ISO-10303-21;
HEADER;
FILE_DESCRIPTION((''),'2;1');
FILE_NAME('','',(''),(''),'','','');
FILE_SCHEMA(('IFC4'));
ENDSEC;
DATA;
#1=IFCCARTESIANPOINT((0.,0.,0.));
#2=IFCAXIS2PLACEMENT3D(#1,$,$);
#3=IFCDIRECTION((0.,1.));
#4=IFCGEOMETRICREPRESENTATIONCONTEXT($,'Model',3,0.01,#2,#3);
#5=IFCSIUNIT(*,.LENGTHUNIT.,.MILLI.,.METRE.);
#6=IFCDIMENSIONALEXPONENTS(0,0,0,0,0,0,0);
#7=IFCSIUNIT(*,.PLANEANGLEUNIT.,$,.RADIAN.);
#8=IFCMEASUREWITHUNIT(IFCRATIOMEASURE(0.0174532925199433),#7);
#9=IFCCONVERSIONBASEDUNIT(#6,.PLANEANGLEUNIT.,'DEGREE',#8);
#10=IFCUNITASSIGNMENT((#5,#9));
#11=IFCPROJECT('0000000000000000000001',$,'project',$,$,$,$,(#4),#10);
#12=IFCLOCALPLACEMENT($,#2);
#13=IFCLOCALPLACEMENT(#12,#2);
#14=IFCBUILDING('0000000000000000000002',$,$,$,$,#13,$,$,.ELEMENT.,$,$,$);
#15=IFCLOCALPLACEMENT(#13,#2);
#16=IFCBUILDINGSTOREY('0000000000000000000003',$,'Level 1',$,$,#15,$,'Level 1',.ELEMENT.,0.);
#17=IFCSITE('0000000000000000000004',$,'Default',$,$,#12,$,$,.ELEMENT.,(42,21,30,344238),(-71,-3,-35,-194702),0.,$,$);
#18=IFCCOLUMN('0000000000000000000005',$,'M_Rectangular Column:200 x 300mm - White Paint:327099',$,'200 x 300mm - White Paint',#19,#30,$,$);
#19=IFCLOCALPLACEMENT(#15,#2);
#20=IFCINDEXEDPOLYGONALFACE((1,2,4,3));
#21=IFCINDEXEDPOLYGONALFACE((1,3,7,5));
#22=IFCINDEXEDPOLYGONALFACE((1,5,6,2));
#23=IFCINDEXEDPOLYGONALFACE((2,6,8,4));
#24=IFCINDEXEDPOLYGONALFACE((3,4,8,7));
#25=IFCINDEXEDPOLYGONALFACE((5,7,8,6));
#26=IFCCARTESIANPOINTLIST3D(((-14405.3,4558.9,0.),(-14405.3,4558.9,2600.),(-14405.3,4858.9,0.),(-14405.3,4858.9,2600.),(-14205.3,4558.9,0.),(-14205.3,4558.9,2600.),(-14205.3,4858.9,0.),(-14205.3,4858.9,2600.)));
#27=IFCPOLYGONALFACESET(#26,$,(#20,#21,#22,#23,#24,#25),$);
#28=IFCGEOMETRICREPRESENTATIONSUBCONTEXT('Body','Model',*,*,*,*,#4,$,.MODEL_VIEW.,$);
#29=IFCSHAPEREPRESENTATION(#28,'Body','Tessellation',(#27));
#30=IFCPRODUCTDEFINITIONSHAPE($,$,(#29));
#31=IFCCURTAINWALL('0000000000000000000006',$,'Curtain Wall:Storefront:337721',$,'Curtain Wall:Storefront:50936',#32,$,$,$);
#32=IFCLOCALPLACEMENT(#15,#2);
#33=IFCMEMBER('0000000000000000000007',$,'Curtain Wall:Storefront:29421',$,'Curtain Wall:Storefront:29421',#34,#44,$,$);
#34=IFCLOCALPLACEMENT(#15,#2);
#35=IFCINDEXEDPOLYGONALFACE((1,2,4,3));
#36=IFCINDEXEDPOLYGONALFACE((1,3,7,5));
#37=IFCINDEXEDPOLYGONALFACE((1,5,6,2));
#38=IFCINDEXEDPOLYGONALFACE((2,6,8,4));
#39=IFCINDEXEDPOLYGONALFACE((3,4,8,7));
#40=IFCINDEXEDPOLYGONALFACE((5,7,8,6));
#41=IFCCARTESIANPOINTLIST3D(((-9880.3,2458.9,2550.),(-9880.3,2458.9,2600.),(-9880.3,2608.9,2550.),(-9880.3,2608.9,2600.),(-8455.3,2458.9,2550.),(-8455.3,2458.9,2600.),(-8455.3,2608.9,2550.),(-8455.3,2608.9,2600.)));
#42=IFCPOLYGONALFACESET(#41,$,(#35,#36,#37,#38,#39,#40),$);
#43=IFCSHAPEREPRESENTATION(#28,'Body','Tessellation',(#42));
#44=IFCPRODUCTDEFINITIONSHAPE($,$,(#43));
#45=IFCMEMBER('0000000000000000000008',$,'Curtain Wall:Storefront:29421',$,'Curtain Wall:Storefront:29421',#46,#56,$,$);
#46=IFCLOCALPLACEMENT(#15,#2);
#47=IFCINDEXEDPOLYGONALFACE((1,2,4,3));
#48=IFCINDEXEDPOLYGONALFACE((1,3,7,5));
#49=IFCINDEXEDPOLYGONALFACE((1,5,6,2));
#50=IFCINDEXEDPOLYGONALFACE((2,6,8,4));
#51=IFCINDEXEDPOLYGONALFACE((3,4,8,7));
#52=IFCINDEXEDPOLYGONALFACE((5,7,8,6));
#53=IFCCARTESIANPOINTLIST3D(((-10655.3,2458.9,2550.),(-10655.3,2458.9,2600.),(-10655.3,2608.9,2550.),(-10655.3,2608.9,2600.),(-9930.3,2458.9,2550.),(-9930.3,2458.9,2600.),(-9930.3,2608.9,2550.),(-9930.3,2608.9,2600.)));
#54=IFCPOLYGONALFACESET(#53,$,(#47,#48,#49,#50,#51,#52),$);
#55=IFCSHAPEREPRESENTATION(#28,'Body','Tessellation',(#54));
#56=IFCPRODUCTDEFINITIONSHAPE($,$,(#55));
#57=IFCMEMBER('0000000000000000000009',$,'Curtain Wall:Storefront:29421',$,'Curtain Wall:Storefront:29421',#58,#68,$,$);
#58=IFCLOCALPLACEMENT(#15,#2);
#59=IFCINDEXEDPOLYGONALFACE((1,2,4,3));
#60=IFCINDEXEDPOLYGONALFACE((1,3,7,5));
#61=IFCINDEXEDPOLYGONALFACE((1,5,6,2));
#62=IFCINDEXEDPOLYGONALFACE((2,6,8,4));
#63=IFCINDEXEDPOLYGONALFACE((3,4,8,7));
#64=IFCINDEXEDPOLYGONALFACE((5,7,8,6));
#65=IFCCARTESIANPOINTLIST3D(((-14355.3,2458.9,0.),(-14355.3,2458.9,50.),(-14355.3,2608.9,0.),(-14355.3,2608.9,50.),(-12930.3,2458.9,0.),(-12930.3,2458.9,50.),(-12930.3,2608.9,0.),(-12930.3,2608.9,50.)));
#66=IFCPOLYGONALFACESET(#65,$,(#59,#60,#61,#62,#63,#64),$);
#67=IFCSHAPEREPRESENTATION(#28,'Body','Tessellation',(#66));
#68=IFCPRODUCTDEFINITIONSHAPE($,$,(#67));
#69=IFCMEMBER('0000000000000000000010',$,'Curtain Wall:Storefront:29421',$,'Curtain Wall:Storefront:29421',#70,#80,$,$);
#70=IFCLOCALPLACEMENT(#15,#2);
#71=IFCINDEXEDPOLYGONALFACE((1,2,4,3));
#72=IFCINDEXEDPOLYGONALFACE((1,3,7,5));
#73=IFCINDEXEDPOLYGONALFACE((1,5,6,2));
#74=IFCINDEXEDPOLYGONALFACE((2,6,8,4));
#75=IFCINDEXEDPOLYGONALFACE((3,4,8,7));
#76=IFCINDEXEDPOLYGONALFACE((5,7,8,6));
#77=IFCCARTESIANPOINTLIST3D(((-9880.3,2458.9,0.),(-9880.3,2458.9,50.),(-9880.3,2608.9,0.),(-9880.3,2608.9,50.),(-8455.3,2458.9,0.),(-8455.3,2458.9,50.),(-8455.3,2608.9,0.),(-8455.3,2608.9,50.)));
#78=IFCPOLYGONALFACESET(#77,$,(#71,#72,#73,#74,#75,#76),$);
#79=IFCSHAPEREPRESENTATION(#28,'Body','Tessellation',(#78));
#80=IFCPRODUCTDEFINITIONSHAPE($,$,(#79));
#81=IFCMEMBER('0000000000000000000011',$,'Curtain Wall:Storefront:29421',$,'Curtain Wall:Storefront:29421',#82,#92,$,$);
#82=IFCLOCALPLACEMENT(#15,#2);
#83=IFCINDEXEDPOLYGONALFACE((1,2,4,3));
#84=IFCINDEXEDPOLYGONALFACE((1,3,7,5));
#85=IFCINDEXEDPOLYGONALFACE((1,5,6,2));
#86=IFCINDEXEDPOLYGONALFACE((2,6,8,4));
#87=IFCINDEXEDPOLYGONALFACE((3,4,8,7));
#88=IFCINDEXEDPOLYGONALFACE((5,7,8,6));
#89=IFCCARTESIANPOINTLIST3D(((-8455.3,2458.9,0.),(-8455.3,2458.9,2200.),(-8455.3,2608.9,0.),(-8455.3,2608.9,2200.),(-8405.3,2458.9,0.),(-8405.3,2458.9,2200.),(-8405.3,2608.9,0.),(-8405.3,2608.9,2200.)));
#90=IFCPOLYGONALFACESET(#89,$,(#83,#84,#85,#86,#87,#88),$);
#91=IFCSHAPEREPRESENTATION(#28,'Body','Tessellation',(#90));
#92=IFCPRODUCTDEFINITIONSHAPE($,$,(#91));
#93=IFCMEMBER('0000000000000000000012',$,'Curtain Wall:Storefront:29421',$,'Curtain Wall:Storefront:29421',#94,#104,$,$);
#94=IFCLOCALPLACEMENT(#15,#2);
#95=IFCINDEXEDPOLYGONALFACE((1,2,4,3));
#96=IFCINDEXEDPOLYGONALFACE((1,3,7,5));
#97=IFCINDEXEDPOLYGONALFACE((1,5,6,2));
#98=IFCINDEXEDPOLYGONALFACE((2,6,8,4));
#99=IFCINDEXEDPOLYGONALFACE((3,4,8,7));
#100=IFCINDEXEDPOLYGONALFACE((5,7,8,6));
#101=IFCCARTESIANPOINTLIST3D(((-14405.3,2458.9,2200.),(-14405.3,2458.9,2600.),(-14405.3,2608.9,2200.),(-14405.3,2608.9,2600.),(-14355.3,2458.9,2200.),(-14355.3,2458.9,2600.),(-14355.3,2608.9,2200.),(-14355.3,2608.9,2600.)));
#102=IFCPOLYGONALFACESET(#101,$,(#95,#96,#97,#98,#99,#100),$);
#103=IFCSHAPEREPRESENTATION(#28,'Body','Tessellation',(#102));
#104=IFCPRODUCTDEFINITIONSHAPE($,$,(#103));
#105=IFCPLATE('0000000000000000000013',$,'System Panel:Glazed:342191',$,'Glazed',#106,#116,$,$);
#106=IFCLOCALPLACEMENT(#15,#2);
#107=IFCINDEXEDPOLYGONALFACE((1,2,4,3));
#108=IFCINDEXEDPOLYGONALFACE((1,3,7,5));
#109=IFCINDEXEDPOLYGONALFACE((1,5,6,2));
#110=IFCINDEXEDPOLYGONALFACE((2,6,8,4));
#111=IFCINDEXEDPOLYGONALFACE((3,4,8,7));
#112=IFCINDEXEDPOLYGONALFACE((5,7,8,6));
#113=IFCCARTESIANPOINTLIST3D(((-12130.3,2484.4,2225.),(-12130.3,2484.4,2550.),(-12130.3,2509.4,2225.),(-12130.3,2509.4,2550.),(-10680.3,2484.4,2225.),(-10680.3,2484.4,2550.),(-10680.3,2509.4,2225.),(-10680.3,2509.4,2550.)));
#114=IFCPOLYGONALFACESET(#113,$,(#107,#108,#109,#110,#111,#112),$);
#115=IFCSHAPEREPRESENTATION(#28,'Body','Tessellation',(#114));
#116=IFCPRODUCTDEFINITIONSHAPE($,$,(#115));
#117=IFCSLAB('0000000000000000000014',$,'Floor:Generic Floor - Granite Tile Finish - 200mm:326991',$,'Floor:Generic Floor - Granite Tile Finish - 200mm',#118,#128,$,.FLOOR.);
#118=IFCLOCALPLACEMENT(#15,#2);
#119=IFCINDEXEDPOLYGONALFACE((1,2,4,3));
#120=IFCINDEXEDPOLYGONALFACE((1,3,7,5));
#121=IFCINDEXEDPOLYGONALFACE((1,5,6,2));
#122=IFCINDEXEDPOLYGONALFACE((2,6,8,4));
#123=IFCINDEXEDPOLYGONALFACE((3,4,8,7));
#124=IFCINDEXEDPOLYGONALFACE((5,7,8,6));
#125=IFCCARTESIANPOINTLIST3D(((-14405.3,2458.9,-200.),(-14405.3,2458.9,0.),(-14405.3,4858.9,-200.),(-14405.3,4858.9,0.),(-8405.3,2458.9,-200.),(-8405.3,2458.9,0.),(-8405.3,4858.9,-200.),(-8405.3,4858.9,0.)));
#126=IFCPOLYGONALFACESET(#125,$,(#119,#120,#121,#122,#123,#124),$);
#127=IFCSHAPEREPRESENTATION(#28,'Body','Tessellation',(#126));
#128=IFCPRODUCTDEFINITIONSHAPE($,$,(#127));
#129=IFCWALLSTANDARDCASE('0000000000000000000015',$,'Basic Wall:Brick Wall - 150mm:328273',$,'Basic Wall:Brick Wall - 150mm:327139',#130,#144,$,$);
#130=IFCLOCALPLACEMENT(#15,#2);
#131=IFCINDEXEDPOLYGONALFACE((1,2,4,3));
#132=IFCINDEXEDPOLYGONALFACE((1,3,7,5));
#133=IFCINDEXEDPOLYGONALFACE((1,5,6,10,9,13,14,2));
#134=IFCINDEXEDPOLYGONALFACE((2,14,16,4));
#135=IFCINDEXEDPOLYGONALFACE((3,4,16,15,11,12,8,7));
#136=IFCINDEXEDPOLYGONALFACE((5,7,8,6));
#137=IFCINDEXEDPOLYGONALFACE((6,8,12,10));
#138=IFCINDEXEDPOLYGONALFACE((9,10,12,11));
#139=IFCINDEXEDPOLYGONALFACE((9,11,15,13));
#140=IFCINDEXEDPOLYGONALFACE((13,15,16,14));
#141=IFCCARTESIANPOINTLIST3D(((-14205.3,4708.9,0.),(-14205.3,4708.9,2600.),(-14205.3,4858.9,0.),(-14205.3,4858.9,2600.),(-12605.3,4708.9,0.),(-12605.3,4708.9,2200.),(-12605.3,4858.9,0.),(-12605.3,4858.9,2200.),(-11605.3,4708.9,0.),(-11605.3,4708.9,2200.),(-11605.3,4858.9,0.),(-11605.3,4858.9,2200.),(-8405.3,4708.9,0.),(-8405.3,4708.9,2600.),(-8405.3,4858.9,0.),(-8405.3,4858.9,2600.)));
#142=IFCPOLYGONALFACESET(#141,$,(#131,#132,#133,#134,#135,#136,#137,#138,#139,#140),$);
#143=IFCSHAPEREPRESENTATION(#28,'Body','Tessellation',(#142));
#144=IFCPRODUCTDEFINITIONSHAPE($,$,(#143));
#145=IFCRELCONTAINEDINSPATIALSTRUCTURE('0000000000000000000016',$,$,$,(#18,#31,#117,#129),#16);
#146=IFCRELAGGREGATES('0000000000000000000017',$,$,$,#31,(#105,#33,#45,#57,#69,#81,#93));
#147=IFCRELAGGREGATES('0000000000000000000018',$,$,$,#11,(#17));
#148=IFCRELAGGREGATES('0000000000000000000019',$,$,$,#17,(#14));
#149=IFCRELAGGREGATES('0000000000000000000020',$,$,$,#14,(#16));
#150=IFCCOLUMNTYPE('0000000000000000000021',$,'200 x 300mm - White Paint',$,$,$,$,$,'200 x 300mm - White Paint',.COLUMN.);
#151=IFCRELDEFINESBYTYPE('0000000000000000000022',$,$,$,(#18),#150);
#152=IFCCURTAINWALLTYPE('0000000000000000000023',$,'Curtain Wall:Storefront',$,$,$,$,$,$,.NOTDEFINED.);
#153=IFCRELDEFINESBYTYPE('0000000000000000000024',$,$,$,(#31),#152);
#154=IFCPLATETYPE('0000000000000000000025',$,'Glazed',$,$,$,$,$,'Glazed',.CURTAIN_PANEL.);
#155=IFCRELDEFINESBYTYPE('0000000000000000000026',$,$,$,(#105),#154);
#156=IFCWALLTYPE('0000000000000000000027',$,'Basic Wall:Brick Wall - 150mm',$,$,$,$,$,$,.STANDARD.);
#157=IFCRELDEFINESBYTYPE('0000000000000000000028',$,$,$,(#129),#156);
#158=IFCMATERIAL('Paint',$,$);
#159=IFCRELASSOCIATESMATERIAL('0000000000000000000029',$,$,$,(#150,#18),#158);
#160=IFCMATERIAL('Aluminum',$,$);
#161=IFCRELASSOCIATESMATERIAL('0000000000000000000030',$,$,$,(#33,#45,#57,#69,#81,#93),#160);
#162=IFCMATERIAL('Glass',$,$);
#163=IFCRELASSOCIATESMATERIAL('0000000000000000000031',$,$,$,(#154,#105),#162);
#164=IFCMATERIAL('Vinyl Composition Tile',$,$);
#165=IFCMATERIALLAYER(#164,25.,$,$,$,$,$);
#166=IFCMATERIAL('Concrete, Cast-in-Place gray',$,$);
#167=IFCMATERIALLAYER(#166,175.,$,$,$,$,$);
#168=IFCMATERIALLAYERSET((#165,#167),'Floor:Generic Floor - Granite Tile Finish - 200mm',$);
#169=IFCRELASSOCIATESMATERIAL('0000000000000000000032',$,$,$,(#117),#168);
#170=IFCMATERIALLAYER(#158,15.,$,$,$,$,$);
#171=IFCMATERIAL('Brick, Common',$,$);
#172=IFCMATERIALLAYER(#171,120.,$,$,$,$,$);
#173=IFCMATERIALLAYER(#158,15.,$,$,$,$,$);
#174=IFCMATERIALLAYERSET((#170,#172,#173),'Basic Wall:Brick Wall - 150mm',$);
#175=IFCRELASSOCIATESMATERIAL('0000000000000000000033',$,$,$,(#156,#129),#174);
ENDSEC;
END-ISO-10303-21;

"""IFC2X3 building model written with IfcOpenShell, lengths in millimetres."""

from ifc_helpers import new_model, entity, si_unit, converted_unit, direction, frame, frame_2d, origin, origin_2d_with_axis, place, context, subcontext, project, spatial, rectangle, extrude, source, transform, mapped, material, layer, layer_set, layer_usage, type_object, type_shapes, element, aggregate, save


model = new_model("IFC2X3")

# Units and contexts
model_context = context("Model", 3, precision=0.01, world=origin(), true_north=direction((0.0, 1.0)))
body_context = subcontext(model_context, "Body", "Model", "MODEL_VIEW")
ifc_project = project(units=[si_unit("LENGTHUNIT", "METRE", prefix="MILLI"), converted_unit("PLANEANGLEUNIT", "DEGREE", entity("IfcRatioMeasure", 0.0174532925199433), si_unit("PLANEANGLEUNIT", "RADIAN"), dimensions=[0, 0, 0, 0, 0, 0, 0])], contexts=[model_context])

# Site, building, storey
site_placement = place(None, origin())
site = spatial("IfcSite", under=ifc_project, at=site_placement, Name="Default", CompositionType="ELEMENT", RefLatitude=(42, 21, 30, 344238), RefLongitude=(-71, -3, -35, -194702), RefElevation=0.0)
building_placement = place(site_placement, origin())
building = spatial("IfcBuilding", under=site, at=building_placement, CompositionType="ELEMENT")
storey_placement = place(building_placement, origin())
storey = spatial("IfcBuildingStorey", under=building, at=storey_placement, Name="Level 1", LongName="Level 1", CompositionType="ELEMENT", Elevation=0.0)

# Column
ifc_material_1 = material(Name="Paint")
column_type = type_object("IfcColumnType", Name="200 x 300mm - White Paint", ElementType="200 x 300mm - White Paint", PredefinedType="COLUMN", material=ifc_material_1)
shared_shape_1 = source(origin(), body_context, "Body", "SweptSolid", [
    extrude(rectangle(XDim=300.0, YDim=200.0, at=origin_2d_with_axis()), frame((-14305.3, 4708.9, 0.0), z_axis=(0.0, 0.0, 1.0), x_axis=(0.0, -1.0, 0.0)), (0.0, 0.0, 1.0), 2600.0),
])
type_shapes(column_type, [shared_shape_1])
column_placement = place(storey_placement, origin())
element("IfcColumn", 1, at=column_placement, inside=storey, type_object=column_type, material=ifc_material_1, Name="M_Rectangular Column:200 x 300mm - White Paint:327099", ObjectType="200 x 300mm - White Paint", context=body_context, shape_type="MappedRepresentation", body=[
    mapped(shared_shape_1, transform((0.0, 0.0, 0.0), scale=1.0)),
])

# Curtain wall, members, plate
curtain_wall_type = type_object("IfcCurtainWallType", Name="Curtain Wall:Storefront", PredefinedType="NOTDEFINED")
curtain_wall_placement = place(storey_placement, origin())
curtain_wall = element("IfcCurtainWall", 2, at=curtain_wall_placement, inside=storey, type_object=curtain_wall_type, Name="Curtain Wall:Storefront:337721", ObjectType="Curtain Wall:Storefront:50936")
ifc_material_2 = material(Name="Aluminum")
member_1_placement = place(curtain_wall_placement, origin())
member_1 = element("IfcMember", 3, at=member_1_placement, material=ifc_material_2, Name="Curtain Wall:Storefront:29421", ObjectType="Curtain Wall:Storefront:29421", context=body_context, shape_type="SweptSolid", body=[
    extrude(rectangle(XDim=50.0, YDim=150.0, at=frame_2d((0.0, 0.0), x_axis=(1.0, 0.0))), frame((-8455.3, 2533.9, 2575.0), z_axis=(-1.0, 0.0, 0.0), x_axis=(0.0, 0.0, -1.0)), (0.0, 0.0, 1.0), 1425.0),
])
member_2_placement = place(curtain_wall_placement, origin())
member_2 = element("IfcMember", 4, at=member_2_placement, material=ifc_material_2, Name="Curtain Wall:Storefront:29421", ObjectType="Curtain Wall:Storefront:29421", context=body_context, shape_type="SweptSolid", body=[
    extrude(rectangle(XDim=50.0, YDim=150.0, at=frame_2d((0.0, 0.0), x_axis=(1.0, 0.0))), frame((-9930.3, 2533.9, 2575.0), z_axis=(-1.0, 0.0, 0.0), x_axis=(0.0, 0.0, -1.0)), (0.0, 0.0, 1.0), 725.0),
])
member_3_placement = place(curtain_wall_placement, origin())
member_3 = element("IfcMember", 5, at=member_3_placement, material=ifc_material_2, Name="Curtain Wall:Storefront:29421", ObjectType="Curtain Wall:Storefront:29421", context=body_context, shape_type="SweptSolid", body=[
    extrude(rectangle(XDim=50.0, YDim=150.0, at=frame_2d((0.0, 0.0), x_axis=(1.0, 0.0))), frame((-14355.3, 2533.9, 25.0), z_axis=(1.0, 0.0, 0.0), x_axis=(0.0, 0.0, -1.0)), (0.0, 0.0, 1.0), 1425.0),
])
member_4_placement = place(curtain_wall_placement, origin())
member_4 = element("IfcMember", 6, at=member_4_placement, material=ifc_material_2, Name="Curtain Wall:Storefront:29421", ObjectType="Curtain Wall:Storefront:29421", context=body_context, shape_type="SweptSolid", body=[
    extrude(rectangle(XDim=50.0, YDim=150.0, at=frame_2d((0.0, 0.0), x_axis=(1.0, 0.0))), frame((-9880.3, 2533.9, 25.0), z_axis=(1.0, 0.0, 0.0), x_axis=(0.0, 0.0, -1.0)), (0.0, 0.0, 1.0), 1425.0),
])
member_5_placement = place(curtain_wall_placement, origin())
member_5 = element("IfcMember", 7, at=member_5_placement, material=ifc_material_2, Name="Curtain Wall:Storefront:29421", ObjectType="Curtain Wall:Storefront:29421", context=body_context, shape_type="SweptSolid", body=[
    extrude(rectangle(XDim=50.0, YDim=150.0, at=origin_2d_with_axis()), frame((-8430.3, 2533.9, 0.0), z_axis=(0.0, 0.0, 1.0), x_axis=(-1.0, 0.0, 0.0)), (0.0, 0.0, 1.0), 2200.0),
])
member_6_placement = place(curtain_wall_placement, origin())
member_6 = element("IfcMember", 8, at=member_6_placement, material=ifc_material_2, Name="Curtain Wall:Storefront:29421", ObjectType="Curtain Wall:Storefront:29421", context=body_context, shape_type="SweptSolid", body=[
    extrude(rectangle(XDim=50.0, YDim=150.0, at=frame_2d((0.0, 0.0), x_axis=(1.0, 0.0))), frame((-14380.3, 2533.9, 2600.0), z_axis=(0.0, 0.0, -1.0), x_axis=(-1.0, 0.0, 0.0)), (0.0, 0.0, 1.0), 400.0),
])
ifc_material_3 = material(Name="Glass")
plate_type_1 = type_object("IfcPlateType", Name="Glazed", ElementType="Glazed", PredefinedType="CURTAIN_PANEL", material=ifc_material_3)
shared_shape_2 = source(origin(), body_context, "Body", "SweptSolid", [
    extrude(rectangle(XDim=325.0, YDim=1450.0, at=frame_2d((0.0, 0.0), x_axis=(1.0, 0.0))), frame((0.0, -49.5, 162.5), z_axis=(0.0, 1.0, 0.0), x_axis=(0.0, 0.0, 1.0)), (0.0, 0.0, 1.0), 25.0),
])
type_shapes(plate_type_1, [shared_shape_2])
plate_1_placement = place(curtain_wall_placement, frame((-11405.3, 2533.9, 2225.0)))
plate_1 = element("IfcPlate", 9, at=plate_1_placement, type_object=plate_type_1, material=ifc_material_3, Name="System Panel:Glazed:342191", ObjectType="Glazed", context=body_context, shape_type="MappedRepresentation", body=[
    mapped(shared_shape_2, transform((0.0, 0.0, 0.0), scale=1.0)),
])

# Slab
ifc_material_4 = material(Name="Vinyl Composition Tile")
ifc_layer_1 = layer(ifc_material_4, 25.0)
ifc_material_5 = material(Name="Concrete, Cast-in-Place gray")
ifc_layer_2 = layer(ifc_material_5, 175.0)
ifc_layer_set_1 = layer_set([ifc_layer_1, ifc_layer_2], Name="Floor:Generic Floor - Granite Tile Finish - 200mm")
ifc_layer_usage_1 = layer_usage(ifc_layer_set_1, "AXIS3", "POSITIVE", 0.0)
slab_placement = place(storey_placement, origin())
element("IfcSlab", 10, at=slab_placement, inside=storey, material=ifc_layer_usage_1, Name="Floor:Generic Floor - Granite Tile Finish - 200mm:326991", ObjectType="Floor:Generic Floor - Granite Tile Finish - 200mm", PredefinedType="FLOOR", context=body_context, shape_type="SweptSolid", body=[
    extrude(rectangle(XDim=2400.0, YDim=6000.0, at=origin_2d_with_axis()), frame((-11405.3, 3658.9, 0.0), z_axis=(0.0, 0.0, -1.0), x_axis=(0.0, 1.0, 0.0)), (0.0, 0.0, 1.0), 200.0),
])

# Wall, opening
ifc_layer_3 = layer(ifc_material_1, 15.0)
ifc_material_6 = material(Name="Brick, Common")
ifc_layer_4 = layer(ifc_material_6, 120.0)
ifc_layer_5 = layer(ifc_material_1, 15.0)
ifc_layer_set_2 = layer_set([ifc_layer_3, ifc_layer_4, ifc_layer_5], Name="Basic Wall:Brick Wall - 150mm")
ifc_layer_usage_2 = layer_usage(ifc_layer_set_2, "AXIS2", "NEGATIVE", 75.0)
wall_type = type_object("IfcWallType", Name="Basic Wall:Brick Wall - 150mm", PredefinedType="STANDARD", material=ifc_layer_set_2)
wall_placement = place(storey_placement, frame((-14205.3, 4783.9, 0.0)))
wall = element("IfcWallStandardCase", 11, at=wall_placement, inside=storey, type_object=wall_type, material=ifc_layer_usage_2, Name="Basic Wall:Brick Wall - 150mm:328273", ObjectType="Basic Wall:Brick Wall - 150mm:327139", context=body_context, shape_type="SweptSolid", body=[
    extrude(rectangle(XDim=5800.0, YDim=150.0, at=frame_2d((2900.0, 0.0), x_axis=(-1.0, 0.0))), origin(), (0.0, 0.0, 1.0), 2600.0),
])
opening_placement = place(wall_placement, frame((1600.0, -75.0, 0.0)))
element("IfcOpeningElement", 12, at=opening_placement, cuts=wall, ObjectType="Opening", context=body_context, shape_type="SweptSolid", body=[
    extrude(rectangle(XDim=2200.0, YDim=1000.0, at=frame_2d((1100.0, 500.0), x_axis=(1.0, 0.0))), frame((0.0, 0.0, 0.0), z_axis=(0.0, 1.0, 0.0), x_axis=(0.0, 0.0, 1.0)), (0.0, 0.0, 1.0), 150.0),
])

aggregate(curtain_wall, [plate_1, member_1, member_2, member_3, member_4, member_5, member_6])

save(model, "model.ifc")
